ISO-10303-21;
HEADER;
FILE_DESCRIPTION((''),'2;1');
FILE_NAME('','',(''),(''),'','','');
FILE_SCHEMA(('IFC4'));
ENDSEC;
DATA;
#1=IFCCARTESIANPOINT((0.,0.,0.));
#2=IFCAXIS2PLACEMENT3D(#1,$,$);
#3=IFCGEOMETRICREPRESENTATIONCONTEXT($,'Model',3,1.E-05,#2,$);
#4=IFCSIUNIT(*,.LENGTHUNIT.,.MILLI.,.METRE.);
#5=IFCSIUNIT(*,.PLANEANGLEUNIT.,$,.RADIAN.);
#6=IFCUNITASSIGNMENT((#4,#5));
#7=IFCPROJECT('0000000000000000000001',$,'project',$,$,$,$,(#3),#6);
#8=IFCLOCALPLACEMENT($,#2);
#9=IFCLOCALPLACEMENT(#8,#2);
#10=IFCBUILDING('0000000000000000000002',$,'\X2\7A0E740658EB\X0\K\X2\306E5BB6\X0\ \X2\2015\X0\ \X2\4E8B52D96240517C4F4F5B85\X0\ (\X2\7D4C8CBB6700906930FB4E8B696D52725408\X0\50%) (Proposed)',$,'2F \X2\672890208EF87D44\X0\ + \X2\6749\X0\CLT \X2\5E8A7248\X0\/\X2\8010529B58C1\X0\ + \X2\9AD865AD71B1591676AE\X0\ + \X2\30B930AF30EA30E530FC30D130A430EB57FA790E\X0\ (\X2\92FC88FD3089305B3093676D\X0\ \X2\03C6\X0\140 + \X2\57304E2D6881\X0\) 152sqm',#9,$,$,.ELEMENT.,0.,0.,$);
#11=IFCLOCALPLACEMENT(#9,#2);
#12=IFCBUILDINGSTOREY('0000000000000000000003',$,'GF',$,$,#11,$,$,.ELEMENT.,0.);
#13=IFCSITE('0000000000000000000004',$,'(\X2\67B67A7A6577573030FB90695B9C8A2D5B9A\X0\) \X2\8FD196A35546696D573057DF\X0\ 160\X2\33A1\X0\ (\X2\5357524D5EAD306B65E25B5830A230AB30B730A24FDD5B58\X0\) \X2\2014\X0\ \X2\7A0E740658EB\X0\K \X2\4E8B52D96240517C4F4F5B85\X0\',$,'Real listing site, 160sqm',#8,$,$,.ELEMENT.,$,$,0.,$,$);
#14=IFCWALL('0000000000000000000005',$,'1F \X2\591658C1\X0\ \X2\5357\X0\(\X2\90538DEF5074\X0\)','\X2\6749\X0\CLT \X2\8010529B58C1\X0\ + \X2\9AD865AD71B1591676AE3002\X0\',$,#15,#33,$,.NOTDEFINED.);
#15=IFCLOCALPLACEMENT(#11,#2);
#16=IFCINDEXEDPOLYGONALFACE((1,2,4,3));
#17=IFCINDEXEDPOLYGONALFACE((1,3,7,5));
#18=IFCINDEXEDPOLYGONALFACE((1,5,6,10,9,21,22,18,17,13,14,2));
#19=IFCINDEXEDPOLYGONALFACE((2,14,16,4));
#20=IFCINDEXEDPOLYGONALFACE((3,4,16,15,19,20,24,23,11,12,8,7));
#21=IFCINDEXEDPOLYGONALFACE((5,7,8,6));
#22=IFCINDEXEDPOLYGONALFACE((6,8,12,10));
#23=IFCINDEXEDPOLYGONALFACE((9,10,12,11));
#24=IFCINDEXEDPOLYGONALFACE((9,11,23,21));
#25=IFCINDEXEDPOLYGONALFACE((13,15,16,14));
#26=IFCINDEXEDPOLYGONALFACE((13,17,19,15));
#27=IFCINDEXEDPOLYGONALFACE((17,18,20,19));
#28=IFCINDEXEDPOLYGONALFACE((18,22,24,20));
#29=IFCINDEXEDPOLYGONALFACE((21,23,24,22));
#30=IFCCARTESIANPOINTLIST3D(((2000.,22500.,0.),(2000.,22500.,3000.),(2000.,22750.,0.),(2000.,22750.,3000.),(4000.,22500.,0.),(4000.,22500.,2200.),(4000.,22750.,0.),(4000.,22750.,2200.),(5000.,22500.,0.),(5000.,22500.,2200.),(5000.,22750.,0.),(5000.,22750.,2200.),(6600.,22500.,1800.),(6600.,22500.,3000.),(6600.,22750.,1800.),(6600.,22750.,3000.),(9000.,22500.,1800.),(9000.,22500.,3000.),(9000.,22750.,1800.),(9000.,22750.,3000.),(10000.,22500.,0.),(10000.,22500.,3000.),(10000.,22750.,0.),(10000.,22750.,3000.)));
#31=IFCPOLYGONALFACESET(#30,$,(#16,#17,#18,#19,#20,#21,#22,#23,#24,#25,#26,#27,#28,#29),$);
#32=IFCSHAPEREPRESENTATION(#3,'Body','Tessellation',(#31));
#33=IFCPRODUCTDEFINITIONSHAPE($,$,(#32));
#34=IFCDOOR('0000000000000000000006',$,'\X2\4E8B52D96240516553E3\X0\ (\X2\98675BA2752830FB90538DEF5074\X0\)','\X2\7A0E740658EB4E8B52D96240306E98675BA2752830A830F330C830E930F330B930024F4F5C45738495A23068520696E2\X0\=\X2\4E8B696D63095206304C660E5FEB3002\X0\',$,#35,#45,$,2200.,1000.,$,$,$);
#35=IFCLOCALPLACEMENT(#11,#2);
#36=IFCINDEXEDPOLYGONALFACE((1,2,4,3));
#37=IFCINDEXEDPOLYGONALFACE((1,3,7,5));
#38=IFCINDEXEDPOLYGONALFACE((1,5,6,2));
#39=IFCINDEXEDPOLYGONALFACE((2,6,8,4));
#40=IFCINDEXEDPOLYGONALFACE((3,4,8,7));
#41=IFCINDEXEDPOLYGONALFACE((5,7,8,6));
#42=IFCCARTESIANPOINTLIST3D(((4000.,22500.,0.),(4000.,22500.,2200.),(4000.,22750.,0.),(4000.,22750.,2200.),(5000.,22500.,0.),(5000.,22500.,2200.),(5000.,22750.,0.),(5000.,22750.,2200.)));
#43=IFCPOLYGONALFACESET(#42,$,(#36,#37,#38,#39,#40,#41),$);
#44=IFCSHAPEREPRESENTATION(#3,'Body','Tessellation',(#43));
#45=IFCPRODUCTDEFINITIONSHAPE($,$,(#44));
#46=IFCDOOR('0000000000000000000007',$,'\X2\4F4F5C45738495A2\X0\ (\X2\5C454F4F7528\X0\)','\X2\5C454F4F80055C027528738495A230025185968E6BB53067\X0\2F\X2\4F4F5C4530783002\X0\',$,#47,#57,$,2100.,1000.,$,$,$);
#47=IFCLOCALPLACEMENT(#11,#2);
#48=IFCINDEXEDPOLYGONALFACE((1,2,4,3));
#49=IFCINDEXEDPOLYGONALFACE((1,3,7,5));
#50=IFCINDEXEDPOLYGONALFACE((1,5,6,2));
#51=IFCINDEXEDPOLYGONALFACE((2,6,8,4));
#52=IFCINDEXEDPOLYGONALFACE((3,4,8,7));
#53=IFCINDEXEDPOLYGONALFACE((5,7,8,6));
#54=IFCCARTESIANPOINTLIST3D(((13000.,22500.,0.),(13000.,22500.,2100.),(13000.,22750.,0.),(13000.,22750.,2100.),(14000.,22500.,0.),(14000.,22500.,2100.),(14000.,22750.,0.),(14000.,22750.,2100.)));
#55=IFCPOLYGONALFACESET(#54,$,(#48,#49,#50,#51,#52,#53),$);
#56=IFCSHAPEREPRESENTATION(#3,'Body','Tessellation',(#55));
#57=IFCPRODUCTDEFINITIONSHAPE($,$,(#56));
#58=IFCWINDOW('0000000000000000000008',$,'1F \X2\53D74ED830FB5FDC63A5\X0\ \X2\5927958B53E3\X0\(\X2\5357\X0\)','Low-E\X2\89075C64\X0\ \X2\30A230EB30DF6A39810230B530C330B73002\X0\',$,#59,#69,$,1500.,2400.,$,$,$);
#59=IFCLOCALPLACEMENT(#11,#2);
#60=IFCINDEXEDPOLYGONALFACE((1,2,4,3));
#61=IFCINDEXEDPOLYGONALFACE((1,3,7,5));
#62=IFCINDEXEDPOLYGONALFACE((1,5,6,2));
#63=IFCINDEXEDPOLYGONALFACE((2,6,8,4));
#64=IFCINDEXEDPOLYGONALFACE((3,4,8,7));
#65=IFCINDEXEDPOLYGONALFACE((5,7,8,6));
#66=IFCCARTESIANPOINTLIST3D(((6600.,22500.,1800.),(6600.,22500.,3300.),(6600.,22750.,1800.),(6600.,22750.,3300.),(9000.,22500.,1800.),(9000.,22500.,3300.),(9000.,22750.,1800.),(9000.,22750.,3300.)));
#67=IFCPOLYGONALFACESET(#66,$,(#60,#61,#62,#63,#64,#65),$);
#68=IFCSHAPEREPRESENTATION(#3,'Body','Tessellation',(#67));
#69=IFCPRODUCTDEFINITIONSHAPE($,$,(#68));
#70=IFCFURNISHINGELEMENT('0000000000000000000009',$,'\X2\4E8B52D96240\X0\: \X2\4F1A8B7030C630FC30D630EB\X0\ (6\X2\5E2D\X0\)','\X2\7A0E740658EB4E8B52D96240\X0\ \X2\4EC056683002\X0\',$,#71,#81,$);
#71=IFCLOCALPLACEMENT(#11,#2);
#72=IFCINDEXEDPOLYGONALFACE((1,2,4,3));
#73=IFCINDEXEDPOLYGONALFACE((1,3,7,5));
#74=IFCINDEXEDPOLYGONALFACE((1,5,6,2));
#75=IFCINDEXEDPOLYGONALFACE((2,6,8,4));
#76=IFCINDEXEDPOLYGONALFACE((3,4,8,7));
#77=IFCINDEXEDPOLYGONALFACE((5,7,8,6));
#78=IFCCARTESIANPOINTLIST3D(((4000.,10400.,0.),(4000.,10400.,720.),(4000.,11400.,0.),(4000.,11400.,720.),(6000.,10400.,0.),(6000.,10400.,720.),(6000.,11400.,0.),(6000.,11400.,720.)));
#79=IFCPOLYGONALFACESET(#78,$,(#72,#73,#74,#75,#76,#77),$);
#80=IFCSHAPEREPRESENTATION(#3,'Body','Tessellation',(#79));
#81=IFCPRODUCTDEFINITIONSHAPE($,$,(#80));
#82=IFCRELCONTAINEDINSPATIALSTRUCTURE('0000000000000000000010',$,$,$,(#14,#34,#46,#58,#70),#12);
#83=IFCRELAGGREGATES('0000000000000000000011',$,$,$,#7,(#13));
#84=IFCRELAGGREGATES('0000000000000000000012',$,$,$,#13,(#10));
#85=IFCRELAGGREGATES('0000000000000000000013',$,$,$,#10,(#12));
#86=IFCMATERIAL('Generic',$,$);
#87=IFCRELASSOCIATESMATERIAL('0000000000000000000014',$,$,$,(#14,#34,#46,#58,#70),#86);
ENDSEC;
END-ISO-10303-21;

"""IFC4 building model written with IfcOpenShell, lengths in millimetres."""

from ifc_helpers import new_model, si_unit, frame, frame_2d, origin, place, context, project, spatial, rectangle, extrude, material, element, fill, save


model = new_model("IFC4")

# Units and contexts
model_context = context("Model", 3, precision=1e-05, world=origin())
ifc_project = project(units=[si_unit("LENGTHUNIT", "METRE", prefix="MILLI"), si_unit("PLANEANGLEUNIT", "RADIAN")], contexts=[model_context])

# Site, building, storey
site_placement = place(None, origin())
site = spatial("IfcSite", under=ifc_project, at=site_placement, Name="(架空敷地・適宜設定) 近隣商業地域 160㎡ (南前庭に既存アカシア保存) — 税理士K 事務所兼住宅", ObjectType="Real listing site, 160sqm", CompositionType="ELEMENT", RefElevation=0.0)
building_placement = place(site_placement, origin())
building = spatial("IfcBuilding", under=site, at=building_placement, Name="税理士Kの家 ― 事務所兼住宅 (経費最適・事業割合50%) (Proposed)", ObjectType="2F 木造軸組 + 杉CLT 床版/耐力壁 + 高断熱外皮 + スクリューパイル基礎 (鋼製らせん杭 φ140 + 地中梁) 152sqm", CompositionType="ELEMENT", ElevationOfRefHeight=0.0, ElevationOfTerrain=0.0)
storey_placement = place(building_placement, origin())
storey = spatial("IfcBuildingStorey", under=building, at=storey_placement, Name="GF", CompositionType="ELEMENT", Elevation=0.0)

# Shared definitions
ifc_material = material(Name="Generic")

# Wall, openings, doors, window
wall_1_placement = place(storey_placement, frame((1000.0, 11250.0, 0.0)))
wall_1 = element("IfcWall", 1, at=wall_1_placement, inside=storey, material=ifc_material, Name="1F 外壁 南(道路側)", Description="杉CLT 耐力壁 + 高断熱外皮。", PredefinedType="NOTDEFINED", context=model_context, shape_type="SweptSolid", body=[
    extrude(rectangle(XDim=8000.0, YDim=250.0, at=frame_2d((4000.0, 125.0))), frame((1000.0, 11250.0, 0.0)), (0.0, 0.0, 1.0), 3000.0),
])
opening_1_placement = place(storey_placement, frame((2000.0, 11250.0, 0.0)))
opening_1 = element("IfcOpeningElement", 2, at=opening_1_placement, cuts=wall_1, PredefinedType="NOTDEFINED", context=model_context, shape_type="SweptSolid", body=[
    extrude(rectangle(XDim=1000.0, YDim=250.0, at=frame_2d((500.0, 125.0))), frame((2000.0, 11250.0, 0.0)), (0.0, 0.0, 1.0), 2200.0),
])
opening_2_placement = place(storey_placement, frame((6500.0, 11250.0, 0.0)))
opening_2 = element("IfcOpeningElement", 3, at=opening_2_placement, cuts=wall_1, PredefinedType="NOTDEFINED", context=model_context, shape_type="SweptSolid", body=[
    extrude(rectangle(XDim=1000.0, YDim=250.0, at=frame_2d((500.0, 125.0))), frame((6500.0, 11250.0, 0.0)), (0.0, 0.0, 1.0), 2100.0),
])
opening_3_placement = place(storey_placement, frame((3300.0, 11250.0, 900.0)))
opening_3 = element("IfcOpeningElement", 4, at=opening_3_placement, cuts=wall_1, PredefinedType="NOTDEFINED", context=model_context, shape_type="SweptSolid", body=[
    extrude(rectangle(XDim=2400.0, YDim=250.0, at=frame_2d((1200.0, 125.0))), frame((3300.0, 11250.0, 900.0)), (0.0, 0.0, 1.0), 1500.0),
])
door_1_placement = place(storey_placement, frame((2000.0, 11250.0, 0.0)))
door_1 = element("IfcDoor", 5, at=door_1_placement, inside=storey, material=ifc_material, Name="事務所入口 (顧客用・道路側)", Description="税理士事務所の顧客用エントランス。住居玄関と分離=事業按分が明快。", OverallHeight=2200.0, OverallWidth=1000.0, context=model_context, shape_type="SweptSolid", body=[
    extrude(rectangle(XDim=1000.0, YDim=250.0, at=frame_2d((500.0, 125.0))), frame((2000.0, 11250.0, 0.0)), (0.0, 0.0, 1.0), 2200.0),
])
fill(opening_1, door_1)
door_2_placement = place(storey_placement, frame((6500.0, 11250.0, 0.0)))
door_2 = element("IfcDoor", 6, at=door_2_placement, inside=storey, material=ifc_material, Name="住居玄関 (居住用)", Description="居住者専用玄関。内階段で2F住居へ。", OverallHeight=2100.0, OverallWidth=1000.0, context=model_context, shape_type="SweptSolid", body=[
    extrude(rectangle(XDim=1000.0, YDim=250.0, at=frame_2d((500.0, 125.0))), frame((6500.0, 11250.0, 0.0)), (0.0, 0.0, 1.0), 2100.0),
])
fill(opening_2, door_2)
window_1_placement = place(storey_placement, frame((3300.0, 11250.0, 900.0)))
window_1 = element("IfcWindow", 7, at=window_1_placement, inside=storey, material=ifc_material, Name="1F 受付・応接 大開口(南)", Description="Low-E複層 アルミ樹脂サッシ。", OverallHeight=1500.0, OverallWidth=2400.0, context=model_context, shape_type="SweptSolid", body=[
    extrude(rectangle(XDim=2400.0, YDim=250.0, at=frame_2d((1200.0, 125.0))), frame((3300.0, 11250.0, 900.0)), (0.0, 0.0, 1.0), 1500.0),
])
fill(opening_3, window_1)

# Furnishing element
furnishing_1_placement = place(storey_placement, frame((2000.0, 5200.0, 0.0)))
element("IfcFurnishingElement", 8, at=furnishing_1_placement, inside=storey, material=ifc_material, Name="事務所: 会議テーブル (6席)", Description="税理士事務所 什器。", context=model_context, shape_type="SweptSolid", body=[
    extrude(rectangle(XDim=2000.0, YDim=1000.0, at=frame_2d((1000.0, 500.0))), frame((2000.0, 5200.0, 0.0)), (0.0, 0.0, 1.0), 720.0),
])

save(model, "model.ifc")
